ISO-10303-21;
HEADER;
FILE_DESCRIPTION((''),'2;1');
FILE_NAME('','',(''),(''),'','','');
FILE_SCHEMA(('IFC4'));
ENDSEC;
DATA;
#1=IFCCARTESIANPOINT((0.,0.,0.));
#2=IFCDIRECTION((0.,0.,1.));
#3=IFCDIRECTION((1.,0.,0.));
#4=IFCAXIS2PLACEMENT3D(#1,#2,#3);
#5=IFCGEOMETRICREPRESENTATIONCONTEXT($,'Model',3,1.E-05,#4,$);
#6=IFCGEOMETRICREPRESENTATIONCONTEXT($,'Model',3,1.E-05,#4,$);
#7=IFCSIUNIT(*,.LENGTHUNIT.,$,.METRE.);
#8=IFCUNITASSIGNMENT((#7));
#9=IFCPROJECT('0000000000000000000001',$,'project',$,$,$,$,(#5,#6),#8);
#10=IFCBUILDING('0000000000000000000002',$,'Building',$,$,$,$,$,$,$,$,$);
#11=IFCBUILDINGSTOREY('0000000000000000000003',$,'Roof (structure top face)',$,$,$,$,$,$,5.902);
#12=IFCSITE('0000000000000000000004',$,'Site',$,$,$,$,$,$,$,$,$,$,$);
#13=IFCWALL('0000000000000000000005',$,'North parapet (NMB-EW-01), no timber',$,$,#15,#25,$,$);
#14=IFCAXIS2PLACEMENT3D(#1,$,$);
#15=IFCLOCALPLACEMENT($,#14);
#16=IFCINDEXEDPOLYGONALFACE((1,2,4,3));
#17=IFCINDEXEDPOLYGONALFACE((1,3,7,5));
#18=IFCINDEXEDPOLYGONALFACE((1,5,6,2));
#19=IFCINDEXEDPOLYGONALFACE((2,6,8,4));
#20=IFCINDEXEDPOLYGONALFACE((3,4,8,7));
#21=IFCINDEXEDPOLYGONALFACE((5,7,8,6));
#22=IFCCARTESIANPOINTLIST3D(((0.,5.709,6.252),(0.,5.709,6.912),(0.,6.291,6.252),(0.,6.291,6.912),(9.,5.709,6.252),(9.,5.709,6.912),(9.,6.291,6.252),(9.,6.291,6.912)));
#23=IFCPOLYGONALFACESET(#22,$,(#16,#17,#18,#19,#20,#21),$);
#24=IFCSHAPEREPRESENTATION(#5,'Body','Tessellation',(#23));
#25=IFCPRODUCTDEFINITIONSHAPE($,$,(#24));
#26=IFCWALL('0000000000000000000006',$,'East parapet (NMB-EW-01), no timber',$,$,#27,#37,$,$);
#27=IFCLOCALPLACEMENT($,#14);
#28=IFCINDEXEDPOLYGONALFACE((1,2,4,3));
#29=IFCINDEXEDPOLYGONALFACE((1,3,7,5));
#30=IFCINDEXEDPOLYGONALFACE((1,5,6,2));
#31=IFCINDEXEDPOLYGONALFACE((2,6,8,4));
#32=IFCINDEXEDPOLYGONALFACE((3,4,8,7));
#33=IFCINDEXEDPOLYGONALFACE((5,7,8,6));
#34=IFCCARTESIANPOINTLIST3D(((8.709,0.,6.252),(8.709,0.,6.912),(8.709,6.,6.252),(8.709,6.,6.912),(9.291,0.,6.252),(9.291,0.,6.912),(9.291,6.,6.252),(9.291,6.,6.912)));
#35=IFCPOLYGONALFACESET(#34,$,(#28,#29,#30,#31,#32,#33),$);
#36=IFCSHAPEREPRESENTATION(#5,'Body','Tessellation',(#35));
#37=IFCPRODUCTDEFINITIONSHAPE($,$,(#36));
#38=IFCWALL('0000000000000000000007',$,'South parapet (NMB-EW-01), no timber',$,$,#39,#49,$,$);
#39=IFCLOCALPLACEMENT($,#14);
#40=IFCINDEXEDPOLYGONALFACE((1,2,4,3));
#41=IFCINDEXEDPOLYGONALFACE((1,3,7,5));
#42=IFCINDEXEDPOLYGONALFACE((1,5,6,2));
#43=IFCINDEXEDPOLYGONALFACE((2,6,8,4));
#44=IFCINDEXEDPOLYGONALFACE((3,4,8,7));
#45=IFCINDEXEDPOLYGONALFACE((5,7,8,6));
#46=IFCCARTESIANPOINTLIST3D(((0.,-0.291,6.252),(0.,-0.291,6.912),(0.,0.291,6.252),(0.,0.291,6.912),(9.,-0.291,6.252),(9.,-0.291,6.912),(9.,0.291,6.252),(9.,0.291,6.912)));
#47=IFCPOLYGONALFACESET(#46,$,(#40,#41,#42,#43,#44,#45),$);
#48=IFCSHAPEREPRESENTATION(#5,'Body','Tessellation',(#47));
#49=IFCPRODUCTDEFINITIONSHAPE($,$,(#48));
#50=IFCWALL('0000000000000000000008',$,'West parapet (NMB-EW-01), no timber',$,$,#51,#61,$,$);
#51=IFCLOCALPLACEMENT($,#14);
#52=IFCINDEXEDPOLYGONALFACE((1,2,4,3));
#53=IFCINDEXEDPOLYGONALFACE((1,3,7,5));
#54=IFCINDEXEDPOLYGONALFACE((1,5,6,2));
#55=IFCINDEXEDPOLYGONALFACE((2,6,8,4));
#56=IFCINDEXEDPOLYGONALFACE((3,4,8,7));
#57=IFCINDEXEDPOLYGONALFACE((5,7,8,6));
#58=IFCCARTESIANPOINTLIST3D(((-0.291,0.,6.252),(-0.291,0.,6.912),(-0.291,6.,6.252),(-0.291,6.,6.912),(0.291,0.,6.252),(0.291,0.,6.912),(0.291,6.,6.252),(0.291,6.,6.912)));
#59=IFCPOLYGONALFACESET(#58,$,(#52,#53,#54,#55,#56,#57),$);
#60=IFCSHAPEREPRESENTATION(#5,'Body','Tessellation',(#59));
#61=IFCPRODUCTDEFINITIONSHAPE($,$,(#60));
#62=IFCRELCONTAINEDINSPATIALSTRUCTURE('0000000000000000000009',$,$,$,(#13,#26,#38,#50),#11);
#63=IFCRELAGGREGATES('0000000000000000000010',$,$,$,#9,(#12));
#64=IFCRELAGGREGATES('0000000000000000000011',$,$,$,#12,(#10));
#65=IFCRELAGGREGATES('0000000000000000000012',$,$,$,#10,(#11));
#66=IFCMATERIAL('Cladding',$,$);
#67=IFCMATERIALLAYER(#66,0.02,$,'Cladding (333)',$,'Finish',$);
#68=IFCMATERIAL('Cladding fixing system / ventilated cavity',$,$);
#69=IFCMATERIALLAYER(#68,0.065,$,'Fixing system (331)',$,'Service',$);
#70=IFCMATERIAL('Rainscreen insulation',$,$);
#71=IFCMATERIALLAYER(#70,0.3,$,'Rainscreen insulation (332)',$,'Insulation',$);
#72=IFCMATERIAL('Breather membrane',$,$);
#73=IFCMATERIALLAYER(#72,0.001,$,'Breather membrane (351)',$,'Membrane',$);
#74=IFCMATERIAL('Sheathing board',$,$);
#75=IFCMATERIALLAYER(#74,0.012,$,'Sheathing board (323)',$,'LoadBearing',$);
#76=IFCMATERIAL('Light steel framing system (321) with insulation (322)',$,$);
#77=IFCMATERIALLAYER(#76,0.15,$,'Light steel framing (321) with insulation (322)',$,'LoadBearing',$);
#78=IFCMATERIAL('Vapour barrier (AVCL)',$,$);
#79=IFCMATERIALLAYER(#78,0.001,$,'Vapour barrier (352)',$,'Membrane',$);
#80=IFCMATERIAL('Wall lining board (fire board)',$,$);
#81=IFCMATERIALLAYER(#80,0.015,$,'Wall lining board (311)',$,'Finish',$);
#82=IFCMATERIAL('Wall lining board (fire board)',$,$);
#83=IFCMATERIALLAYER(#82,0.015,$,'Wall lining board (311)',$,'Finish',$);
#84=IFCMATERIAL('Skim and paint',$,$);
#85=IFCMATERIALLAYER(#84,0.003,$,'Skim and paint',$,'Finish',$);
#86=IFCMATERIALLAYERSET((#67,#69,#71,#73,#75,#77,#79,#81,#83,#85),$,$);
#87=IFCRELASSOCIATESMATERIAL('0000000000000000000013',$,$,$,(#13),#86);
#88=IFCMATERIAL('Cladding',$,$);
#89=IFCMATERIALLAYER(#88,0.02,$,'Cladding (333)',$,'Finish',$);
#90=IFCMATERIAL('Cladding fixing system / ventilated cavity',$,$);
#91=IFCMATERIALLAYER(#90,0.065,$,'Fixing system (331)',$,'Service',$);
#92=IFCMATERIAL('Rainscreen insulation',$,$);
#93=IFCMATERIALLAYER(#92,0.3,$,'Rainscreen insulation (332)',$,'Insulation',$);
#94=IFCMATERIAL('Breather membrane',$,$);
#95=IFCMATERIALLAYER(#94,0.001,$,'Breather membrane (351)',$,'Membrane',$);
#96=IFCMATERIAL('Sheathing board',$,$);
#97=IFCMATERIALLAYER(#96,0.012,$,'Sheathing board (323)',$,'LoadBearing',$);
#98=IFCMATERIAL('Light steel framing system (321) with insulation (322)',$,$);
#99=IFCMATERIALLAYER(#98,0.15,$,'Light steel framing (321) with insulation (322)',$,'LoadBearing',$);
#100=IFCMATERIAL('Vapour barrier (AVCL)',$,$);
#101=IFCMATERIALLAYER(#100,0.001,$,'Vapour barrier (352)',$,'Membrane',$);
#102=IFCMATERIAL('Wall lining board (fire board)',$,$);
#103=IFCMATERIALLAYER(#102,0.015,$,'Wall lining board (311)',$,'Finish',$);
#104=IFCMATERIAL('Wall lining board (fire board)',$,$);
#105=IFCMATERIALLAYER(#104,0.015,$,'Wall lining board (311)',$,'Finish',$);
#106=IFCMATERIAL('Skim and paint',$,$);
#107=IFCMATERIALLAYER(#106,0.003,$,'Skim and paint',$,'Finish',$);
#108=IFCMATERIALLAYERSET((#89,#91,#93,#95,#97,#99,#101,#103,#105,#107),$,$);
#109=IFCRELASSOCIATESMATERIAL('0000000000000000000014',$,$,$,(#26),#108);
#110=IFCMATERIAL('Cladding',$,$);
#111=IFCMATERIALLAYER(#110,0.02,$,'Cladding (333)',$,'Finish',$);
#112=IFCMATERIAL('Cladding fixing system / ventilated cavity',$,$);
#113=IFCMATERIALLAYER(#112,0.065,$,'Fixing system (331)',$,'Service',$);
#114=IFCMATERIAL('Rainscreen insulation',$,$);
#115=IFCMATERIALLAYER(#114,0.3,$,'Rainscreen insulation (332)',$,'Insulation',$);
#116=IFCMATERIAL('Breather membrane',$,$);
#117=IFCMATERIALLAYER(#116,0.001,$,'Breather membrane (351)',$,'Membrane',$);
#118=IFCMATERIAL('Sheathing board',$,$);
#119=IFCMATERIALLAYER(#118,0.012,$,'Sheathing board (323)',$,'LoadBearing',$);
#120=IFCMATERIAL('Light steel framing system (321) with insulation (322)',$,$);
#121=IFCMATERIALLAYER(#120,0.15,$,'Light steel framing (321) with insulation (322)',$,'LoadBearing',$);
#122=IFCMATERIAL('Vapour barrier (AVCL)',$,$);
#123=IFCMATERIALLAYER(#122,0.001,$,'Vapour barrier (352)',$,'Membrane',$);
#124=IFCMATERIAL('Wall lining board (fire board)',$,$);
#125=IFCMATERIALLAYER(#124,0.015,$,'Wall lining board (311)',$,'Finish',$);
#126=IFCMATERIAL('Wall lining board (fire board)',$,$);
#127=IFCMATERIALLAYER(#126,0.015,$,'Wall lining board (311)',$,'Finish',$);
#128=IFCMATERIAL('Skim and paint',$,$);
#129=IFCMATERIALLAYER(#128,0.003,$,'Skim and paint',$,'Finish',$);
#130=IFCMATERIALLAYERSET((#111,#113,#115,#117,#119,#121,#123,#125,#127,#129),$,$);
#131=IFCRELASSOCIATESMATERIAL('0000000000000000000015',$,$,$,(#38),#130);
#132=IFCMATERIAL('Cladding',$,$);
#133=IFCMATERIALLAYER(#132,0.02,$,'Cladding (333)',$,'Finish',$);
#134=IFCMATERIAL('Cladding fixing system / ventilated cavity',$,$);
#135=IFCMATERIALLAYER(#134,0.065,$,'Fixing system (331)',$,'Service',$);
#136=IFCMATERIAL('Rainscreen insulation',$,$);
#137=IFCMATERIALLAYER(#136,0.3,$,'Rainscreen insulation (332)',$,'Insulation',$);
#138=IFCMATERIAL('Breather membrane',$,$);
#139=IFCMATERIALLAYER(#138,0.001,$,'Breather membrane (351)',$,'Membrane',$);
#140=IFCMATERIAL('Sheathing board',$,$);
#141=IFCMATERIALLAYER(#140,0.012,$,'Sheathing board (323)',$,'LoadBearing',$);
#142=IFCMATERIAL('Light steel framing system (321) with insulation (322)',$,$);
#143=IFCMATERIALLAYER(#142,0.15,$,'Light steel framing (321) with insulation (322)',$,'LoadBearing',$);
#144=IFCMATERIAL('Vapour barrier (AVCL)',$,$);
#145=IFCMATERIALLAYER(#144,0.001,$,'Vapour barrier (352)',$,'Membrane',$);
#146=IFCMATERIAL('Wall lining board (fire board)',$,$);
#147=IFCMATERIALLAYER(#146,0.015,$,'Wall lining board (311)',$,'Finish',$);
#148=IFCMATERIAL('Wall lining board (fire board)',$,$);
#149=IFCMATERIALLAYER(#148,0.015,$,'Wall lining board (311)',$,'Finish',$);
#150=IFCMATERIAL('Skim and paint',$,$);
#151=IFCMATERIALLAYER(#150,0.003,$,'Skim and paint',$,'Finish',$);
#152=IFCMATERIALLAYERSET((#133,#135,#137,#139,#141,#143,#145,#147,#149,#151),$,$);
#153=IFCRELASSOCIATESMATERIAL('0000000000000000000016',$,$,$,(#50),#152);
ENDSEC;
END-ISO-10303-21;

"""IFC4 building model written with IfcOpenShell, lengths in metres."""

from ifc_helpers import new_model, si_unit, frame, frame_2d, origin_with_axes, place, context, project, spatial, rectangle, extrude, material, layer, layer_set, layer_usage, element, save


model = new_model("IFC4")

# Units and contexts
model_context_1 = context("Model", 3, precision=1e-05, world=origin_with_axes())
model_context_2 = context("Model", 3, precision=1e-05, world=origin_with_axes())
ifc_project = project(units=[si_unit("LENGTHUNIT", "METRE")], contexts=[model_context_1, model_context_2])

# Site, building, storey
site = spatial("IfcSite", under=ifc_project, Name="Site")
building = spatial("IfcBuilding", under=site, Name="Building")
storey = spatial("IfcBuildingStorey", under=building, Name="Roof (structure top face)", Elevation=5.902)

# Walls
ifc_material_1 = material(Name="Cladding")
ifc_layer_1 = layer(ifc_material_1, 0.02, Name="Cladding (333)", Category="Finish")
ifc_material_2 = material(Name="Cladding fixing system / ventilated cavity")
ifc_layer_2 = layer(ifc_material_2, 0.065, Name="Fixing system (331)", Category="Service")
ifc_material_3 = material(Name="Rainscreen insulation")
ifc_layer_3 = layer(ifc_material_3, 0.3, Name="Rainscreen insulation (332)", Category="Insulation")
ifc_material_4 = material(Name="Breather membrane")
ifc_layer_4 = layer(ifc_material_4, 0.001, Name="Breather membrane (351)", Category="Membrane")
ifc_material_5 = material(Name="Sheathing board")
ifc_layer_5 = layer(ifc_material_5, 0.012, Name="Sheathing board (323)", Category="LoadBearing")
ifc_material_6 = material(Name="Light steel framing system (321) with insulation (322)")
ifc_layer_6 = layer(ifc_material_6, 0.15, Name="Light steel framing (321) with insulation (322)", Category="LoadBearing")
ifc_material_7 = material(Name="Vapour barrier (AVCL)")
ifc_layer_7 = layer(ifc_material_7, 0.001, Name="Vapour barrier (352)", Category="Membrane")
ifc_material_8 = material(Name="Wall lining board (fire board)")
ifc_layer_8 = layer(ifc_material_8, 0.015, Name="Wall lining board (311)", Category="Finish")
ifc_material_9 = material(Name="Wall lining board (fire board)")
ifc_layer_9 = layer(ifc_material_9, 0.015, Name="Wall lining board (311)", Category="Finish")
ifc_material_10 = material(Name="Skim and paint")
ifc_layer_10 = layer(ifc_material_10, 0.003, Name="Skim and paint", Category="Finish")
ifc_layer_set_1 = layer_set([ifc_layer_1, ifc_layer_2, ifc_layer_3, ifc_layer_4, ifc_layer_5, ifc_layer_6, ifc_layer_7, ifc_layer_8, ifc_layer_9, ifc_layer_10])
ifc_layer_usage_1 = layer_usage(ifc_layer_set_1, "AXIS2", "NEGATIVE", 0.291)
wall_1_placement = place(None, frame((0.0, 6.0, 6.252), z_axis=(0.0, 0.0, 1.0), x_axis=(1.0, 0.0, 0.0)))
element("IfcWall", 1, at=wall_1_placement, inside=storey, material=ifc_layer_usage_1, Name="North parapet (NMB-EW-01), no timber", context=model_context_1, shape_type="SweptSolid", body=[
    extrude(rectangle(XDim=0.582, YDim=0.66, at=frame_2d((0.0, 0.33))), frame((0.0, 0.0, 0.0), z_axis=(1.0, 0.0, 0.0), x_axis=(0.0, 1.0, 0.0)), (0.0, 0.0, 1.0), 9.0),
])
ifc_material_11 = material(Name="Cladding")
ifc_layer_11 = layer(ifc_material_11, 0.02, Name="Cladding (333)", Category="Finish")
ifc_material_12 = material(Name="Cladding fixing system / ventilated cavity")
ifc_layer_12 = layer(ifc_material_12, 0.065, Name="Fixing system (331)", Category="Service")
ifc_material_13 = material(Name="Rainscreen insulation")
ifc_layer_13 = layer(ifc_material_13, 0.3, Name="Rainscreen insulation (332)", Category="Insulation")
ifc_material_14 = material(Name="Breather membrane")
ifc_layer_14 = layer(ifc_material_14, 0.001, Name="Breather membrane (351)", Category="Membrane")
ifc_material_15 = material(Name="Sheathing board")
ifc_layer_15 = layer(ifc_material_15, 0.012, Name="Sheathing board (323)", Category="LoadBearing")
ifc_material_16 = material(Name="Light steel framing system (321) with insulation (322)")
ifc_layer_16 = layer(ifc_material_16, 0.15, Name="Light steel framing (321) with insulation (322)", Category="LoadBearing")
ifc_material_17 = material(Name="Vapour barrier (AVCL)")
ifc_layer_17 = layer(ifc_material_17, 0.001, Name="Vapour barrier (352)", Category="Membrane")
ifc_material_18 = material(Name="Wall lining board (fire board)")
ifc_layer_18 = layer(ifc_material_18, 0.015, Name="Wall lining board (311)", Category="Finish")
ifc_material_19 = material(Name="Wall lining board (fire board)")
ifc_layer_19 = layer(ifc_material_19, 0.015, Name="Wall lining board (311)", Category="Finish")
ifc_material_20 = material(Name="Skim and paint")
ifc_layer_20 = layer(ifc_material_20, 0.003, Name="Skim and paint", Category="Finish")
ifc_layer_set_2 = layer_set([ifc_layer_11, ifc_layer_12, ifc_layer_13, ifc_layer_14, ifc_layer_15, ifc_layer_16, ifc_layer_17, ifc_layer_18, ifc_layer_19, ifc_layer_20])
ifc_layer_usage_2 = layer_usage(ifc_layer_set_2, "AXIS2", "NEGATIVE", 0.291)
wall_2_placement = place(None, frame((9.0, 6.0, 6.252), z_axis=(0.0, 0.0, 1.0), x_axis=(0.0, -1.0, 0.0)))
element("IfcWall", 2, at=wall_2_placement, inside=storey, material=ifc_layer_usage_2, Name="East parapet (NMB-EW-01), no timber", context=model_context_1, shape_type="SweptSolid", body=[
    extrude(rectangle(XDim=0.582, YDim=0.66, at=frame_2d((0.0, 0.33))), frame((0.0, 0.0, 0.0), z_axis=(1.0, 0.0, 0.0), x_axis=(0.0, 1.0, 0.0)), (0.0, 0.0, 1.0), 6.0),
])
ifc_material_21 = material(Name="Cladding")
ifc_layer_21 = layer(ifc_material_21, 0.02, Name="Cladding (333)", Category="Finish")
ifc_material_22 = material(Name="Cladding fixing system / ventilated cavity")
ifc_layer_22 = layer(ifc_material_22, 0.065, Name="Fixing system (331)", Category="Service")
ifc_material_23 = material(Name="Rainscreen insulation")
ifc_layer_23 = layer(ifc_material_23, 0.3, Name="Rainscreen insulation (332)", Category="Insulation")
ifc_material_24 = material(Name="Breather membrane")
ifc_layer_24 = layer(ifc_material_24, 0.001, Name="Breather membrane (351)", Category="Membrane")
ifc_material_25 = material(Name="Sheathing board")
ifc_layer_25 = layer(ifc_material_25, 0.012, Name="Sheathing board (323)", Category="LoadBearing")
ifc_material_26 = material(Name="Light steel framing system (321) with insulation (322)")
ifc_layer_26 = layer(ifc_material_26, 0.15, Name="Light steel framing (321) with insulation (322)", Category="LoadBearing")
ifc_material_27 = material(Name="Vapour barrier (AVCL)")
ifc_layer_27 = layer(ifc_material_27, 0.001, Name="Vapour barrier (352)", Category="Membrane")
ifc_material_28 = material(Name="Wall lining board (fire board)")
ifc_layer_28 = layer(ifc_material_28, 0.015, Name="Wall lining board (311)", Category="Finish")
ifc_material_29 = material(Name="Wall lining board (fire board)")
ifc_layer_29 = layer(ifc_material_29, 0.015, Name="Wall lining board (311)", Category="Finish")
ifc_material_30 = material(Name="Skim and paint")
ifc_layer_30 = layer(ifc_material_30, 0.003, Name="Skim and paint", Category="Finish")
ifc_layer_set_3 = layer_set([ifc_layer_21, ifc_layer_22, ifc_layer_23, ifc_layer_24, ifc_layer_25, ifc_layer_26, ifc_layer_27, ifc_layer_28, ifc_layer_29, ifc_layer_30])
ifc_layer_usage_3 = layer_usage(ifc_layer_set_3, "AXIS2", "NEGATIVE", 0.291)
wall_3_placement = place(None, frame((9.0, 0.0, 6.252), z_axis=(0.0, 0.0, 1.0), x_axis=(-1.0, 0.0, 0.0)))
element("IfcWall", 3, at=wall_3_placement, inside=storey, material=ifc_layer_usage_3, Name="South parapet (NMB-EW-01), no timber", context=model_context_1, shape_type="SweptSolid", body=[
    extrude(rectangle(XDim=0.582, YDim=0.66, at=frame_2d((0.0, 0.33))), frame((0.0, 0.0, 0.0), z_axis=(1.0, 0.0, 0.0), x_axis=(0.0, 1.0, 0.0)), (0.0, 0.0, 1.0), 9.0),
])
ifc_material_31 = material(Name="Cladding")
ifc_layer_31 = layer(ifc_material_31, 0.02, Name="Cladding (333)", Category="Finish")
ifc_material_32 = material(Name="Cladding fixing system / ventilated cavity")
ifc_layer_32 = layer(ifc_material_32, 0.065, Name="Fixing system (331)", Category="Service")
ifc_material_33 = material(Name="Rainscreen insulation")
ifc_layer_33 = layer(ifc_material_33, 0.3, Name="Rainscreen insulation (332)", Category="Insulation")
ifc_material_34 = material(Name="Breather membrane")
ifc_layer_34 = layer(ifc_material_34, 0.001, Name="Breather membrane (351)", Category="Membrane")
ifc_material_35 = material(Name="Sheathing board")
ifc_layer_35 = layer(ifc_material_35, 0.012, Name="Sheathing board (323)", Category="LoadBearing")
ifc_material_36 = material(Name="Light steel framing system (321) with insulation (322)")
ifc_layer_36 = layer(ifc_material_36, 0.15, Name="Light steel framing (321) with insulation (322)", Category="LoadBearing")
ifc_material_37 = material(Name="Vapour barrier (AVCL)")
ifc_layer_37 = layer(ifc_material_37, 0.001, Name="Vapour barrier (352)", Category="Membrane")
ifc_material_38 = material(Name="Wall lining board (fire board)")
ifc_layer_38 = layer(ifc_material_38, 0.015, Name="Wall lining board (311)", Category="Finish")
ifc_material_39 = material(Name="Wall lining board (fire board)")
ifc_layer_39 = layer(ifc_material_39, 0.015, Name="Wall lining board (311)", Category="Finish")
ifc_material_40 = material(Name="Skim and paint")
ifc_layer_40 = layer(ifc_material_40, 0.003, Name="Skim and paint", Category="Finish")
ifc_layer_set_4 = layer_set([ifc_layer_31, ifc_layer_32, ifc_layer_33, ifc_layer_34, ifc_layer_35, ifc_layer_36, ifc_layer_37, ifc_layer_38, ifc_layer_39, ifc_layer_40])
ifc_layer_usage_4 = layer_usage(ifc_layer_set_4, "AXIS2", "NEGATIVE", 0.291)
wall_4_placement = place(None, frame((0.0, 0.0, 6.252), z_axis=(0.0, 0.0, 1.0), x_axis=(0.0, 1.0, 0.0)))
element("IfcWall", 4, at=wall_4_placement, inside=storey, material=ifc_layer_usage_4, Name="West parapet (NMB-EW-01), no timber", context=model_context_1, shape_type="SweptSolid", body=[
    extrude(rectangle(XDim=0.582, YDim=0.66, at=frame_2d((0.0, 0.33))), frame((0.0, 0.0, 0.0), z_axis=(1.0, 0.0, 0.0), x_axis=(0.0, 1.0, 0.0)), (0.0, 0.0, 1.0), 6.0),
])

save(model, "model.ifc")
